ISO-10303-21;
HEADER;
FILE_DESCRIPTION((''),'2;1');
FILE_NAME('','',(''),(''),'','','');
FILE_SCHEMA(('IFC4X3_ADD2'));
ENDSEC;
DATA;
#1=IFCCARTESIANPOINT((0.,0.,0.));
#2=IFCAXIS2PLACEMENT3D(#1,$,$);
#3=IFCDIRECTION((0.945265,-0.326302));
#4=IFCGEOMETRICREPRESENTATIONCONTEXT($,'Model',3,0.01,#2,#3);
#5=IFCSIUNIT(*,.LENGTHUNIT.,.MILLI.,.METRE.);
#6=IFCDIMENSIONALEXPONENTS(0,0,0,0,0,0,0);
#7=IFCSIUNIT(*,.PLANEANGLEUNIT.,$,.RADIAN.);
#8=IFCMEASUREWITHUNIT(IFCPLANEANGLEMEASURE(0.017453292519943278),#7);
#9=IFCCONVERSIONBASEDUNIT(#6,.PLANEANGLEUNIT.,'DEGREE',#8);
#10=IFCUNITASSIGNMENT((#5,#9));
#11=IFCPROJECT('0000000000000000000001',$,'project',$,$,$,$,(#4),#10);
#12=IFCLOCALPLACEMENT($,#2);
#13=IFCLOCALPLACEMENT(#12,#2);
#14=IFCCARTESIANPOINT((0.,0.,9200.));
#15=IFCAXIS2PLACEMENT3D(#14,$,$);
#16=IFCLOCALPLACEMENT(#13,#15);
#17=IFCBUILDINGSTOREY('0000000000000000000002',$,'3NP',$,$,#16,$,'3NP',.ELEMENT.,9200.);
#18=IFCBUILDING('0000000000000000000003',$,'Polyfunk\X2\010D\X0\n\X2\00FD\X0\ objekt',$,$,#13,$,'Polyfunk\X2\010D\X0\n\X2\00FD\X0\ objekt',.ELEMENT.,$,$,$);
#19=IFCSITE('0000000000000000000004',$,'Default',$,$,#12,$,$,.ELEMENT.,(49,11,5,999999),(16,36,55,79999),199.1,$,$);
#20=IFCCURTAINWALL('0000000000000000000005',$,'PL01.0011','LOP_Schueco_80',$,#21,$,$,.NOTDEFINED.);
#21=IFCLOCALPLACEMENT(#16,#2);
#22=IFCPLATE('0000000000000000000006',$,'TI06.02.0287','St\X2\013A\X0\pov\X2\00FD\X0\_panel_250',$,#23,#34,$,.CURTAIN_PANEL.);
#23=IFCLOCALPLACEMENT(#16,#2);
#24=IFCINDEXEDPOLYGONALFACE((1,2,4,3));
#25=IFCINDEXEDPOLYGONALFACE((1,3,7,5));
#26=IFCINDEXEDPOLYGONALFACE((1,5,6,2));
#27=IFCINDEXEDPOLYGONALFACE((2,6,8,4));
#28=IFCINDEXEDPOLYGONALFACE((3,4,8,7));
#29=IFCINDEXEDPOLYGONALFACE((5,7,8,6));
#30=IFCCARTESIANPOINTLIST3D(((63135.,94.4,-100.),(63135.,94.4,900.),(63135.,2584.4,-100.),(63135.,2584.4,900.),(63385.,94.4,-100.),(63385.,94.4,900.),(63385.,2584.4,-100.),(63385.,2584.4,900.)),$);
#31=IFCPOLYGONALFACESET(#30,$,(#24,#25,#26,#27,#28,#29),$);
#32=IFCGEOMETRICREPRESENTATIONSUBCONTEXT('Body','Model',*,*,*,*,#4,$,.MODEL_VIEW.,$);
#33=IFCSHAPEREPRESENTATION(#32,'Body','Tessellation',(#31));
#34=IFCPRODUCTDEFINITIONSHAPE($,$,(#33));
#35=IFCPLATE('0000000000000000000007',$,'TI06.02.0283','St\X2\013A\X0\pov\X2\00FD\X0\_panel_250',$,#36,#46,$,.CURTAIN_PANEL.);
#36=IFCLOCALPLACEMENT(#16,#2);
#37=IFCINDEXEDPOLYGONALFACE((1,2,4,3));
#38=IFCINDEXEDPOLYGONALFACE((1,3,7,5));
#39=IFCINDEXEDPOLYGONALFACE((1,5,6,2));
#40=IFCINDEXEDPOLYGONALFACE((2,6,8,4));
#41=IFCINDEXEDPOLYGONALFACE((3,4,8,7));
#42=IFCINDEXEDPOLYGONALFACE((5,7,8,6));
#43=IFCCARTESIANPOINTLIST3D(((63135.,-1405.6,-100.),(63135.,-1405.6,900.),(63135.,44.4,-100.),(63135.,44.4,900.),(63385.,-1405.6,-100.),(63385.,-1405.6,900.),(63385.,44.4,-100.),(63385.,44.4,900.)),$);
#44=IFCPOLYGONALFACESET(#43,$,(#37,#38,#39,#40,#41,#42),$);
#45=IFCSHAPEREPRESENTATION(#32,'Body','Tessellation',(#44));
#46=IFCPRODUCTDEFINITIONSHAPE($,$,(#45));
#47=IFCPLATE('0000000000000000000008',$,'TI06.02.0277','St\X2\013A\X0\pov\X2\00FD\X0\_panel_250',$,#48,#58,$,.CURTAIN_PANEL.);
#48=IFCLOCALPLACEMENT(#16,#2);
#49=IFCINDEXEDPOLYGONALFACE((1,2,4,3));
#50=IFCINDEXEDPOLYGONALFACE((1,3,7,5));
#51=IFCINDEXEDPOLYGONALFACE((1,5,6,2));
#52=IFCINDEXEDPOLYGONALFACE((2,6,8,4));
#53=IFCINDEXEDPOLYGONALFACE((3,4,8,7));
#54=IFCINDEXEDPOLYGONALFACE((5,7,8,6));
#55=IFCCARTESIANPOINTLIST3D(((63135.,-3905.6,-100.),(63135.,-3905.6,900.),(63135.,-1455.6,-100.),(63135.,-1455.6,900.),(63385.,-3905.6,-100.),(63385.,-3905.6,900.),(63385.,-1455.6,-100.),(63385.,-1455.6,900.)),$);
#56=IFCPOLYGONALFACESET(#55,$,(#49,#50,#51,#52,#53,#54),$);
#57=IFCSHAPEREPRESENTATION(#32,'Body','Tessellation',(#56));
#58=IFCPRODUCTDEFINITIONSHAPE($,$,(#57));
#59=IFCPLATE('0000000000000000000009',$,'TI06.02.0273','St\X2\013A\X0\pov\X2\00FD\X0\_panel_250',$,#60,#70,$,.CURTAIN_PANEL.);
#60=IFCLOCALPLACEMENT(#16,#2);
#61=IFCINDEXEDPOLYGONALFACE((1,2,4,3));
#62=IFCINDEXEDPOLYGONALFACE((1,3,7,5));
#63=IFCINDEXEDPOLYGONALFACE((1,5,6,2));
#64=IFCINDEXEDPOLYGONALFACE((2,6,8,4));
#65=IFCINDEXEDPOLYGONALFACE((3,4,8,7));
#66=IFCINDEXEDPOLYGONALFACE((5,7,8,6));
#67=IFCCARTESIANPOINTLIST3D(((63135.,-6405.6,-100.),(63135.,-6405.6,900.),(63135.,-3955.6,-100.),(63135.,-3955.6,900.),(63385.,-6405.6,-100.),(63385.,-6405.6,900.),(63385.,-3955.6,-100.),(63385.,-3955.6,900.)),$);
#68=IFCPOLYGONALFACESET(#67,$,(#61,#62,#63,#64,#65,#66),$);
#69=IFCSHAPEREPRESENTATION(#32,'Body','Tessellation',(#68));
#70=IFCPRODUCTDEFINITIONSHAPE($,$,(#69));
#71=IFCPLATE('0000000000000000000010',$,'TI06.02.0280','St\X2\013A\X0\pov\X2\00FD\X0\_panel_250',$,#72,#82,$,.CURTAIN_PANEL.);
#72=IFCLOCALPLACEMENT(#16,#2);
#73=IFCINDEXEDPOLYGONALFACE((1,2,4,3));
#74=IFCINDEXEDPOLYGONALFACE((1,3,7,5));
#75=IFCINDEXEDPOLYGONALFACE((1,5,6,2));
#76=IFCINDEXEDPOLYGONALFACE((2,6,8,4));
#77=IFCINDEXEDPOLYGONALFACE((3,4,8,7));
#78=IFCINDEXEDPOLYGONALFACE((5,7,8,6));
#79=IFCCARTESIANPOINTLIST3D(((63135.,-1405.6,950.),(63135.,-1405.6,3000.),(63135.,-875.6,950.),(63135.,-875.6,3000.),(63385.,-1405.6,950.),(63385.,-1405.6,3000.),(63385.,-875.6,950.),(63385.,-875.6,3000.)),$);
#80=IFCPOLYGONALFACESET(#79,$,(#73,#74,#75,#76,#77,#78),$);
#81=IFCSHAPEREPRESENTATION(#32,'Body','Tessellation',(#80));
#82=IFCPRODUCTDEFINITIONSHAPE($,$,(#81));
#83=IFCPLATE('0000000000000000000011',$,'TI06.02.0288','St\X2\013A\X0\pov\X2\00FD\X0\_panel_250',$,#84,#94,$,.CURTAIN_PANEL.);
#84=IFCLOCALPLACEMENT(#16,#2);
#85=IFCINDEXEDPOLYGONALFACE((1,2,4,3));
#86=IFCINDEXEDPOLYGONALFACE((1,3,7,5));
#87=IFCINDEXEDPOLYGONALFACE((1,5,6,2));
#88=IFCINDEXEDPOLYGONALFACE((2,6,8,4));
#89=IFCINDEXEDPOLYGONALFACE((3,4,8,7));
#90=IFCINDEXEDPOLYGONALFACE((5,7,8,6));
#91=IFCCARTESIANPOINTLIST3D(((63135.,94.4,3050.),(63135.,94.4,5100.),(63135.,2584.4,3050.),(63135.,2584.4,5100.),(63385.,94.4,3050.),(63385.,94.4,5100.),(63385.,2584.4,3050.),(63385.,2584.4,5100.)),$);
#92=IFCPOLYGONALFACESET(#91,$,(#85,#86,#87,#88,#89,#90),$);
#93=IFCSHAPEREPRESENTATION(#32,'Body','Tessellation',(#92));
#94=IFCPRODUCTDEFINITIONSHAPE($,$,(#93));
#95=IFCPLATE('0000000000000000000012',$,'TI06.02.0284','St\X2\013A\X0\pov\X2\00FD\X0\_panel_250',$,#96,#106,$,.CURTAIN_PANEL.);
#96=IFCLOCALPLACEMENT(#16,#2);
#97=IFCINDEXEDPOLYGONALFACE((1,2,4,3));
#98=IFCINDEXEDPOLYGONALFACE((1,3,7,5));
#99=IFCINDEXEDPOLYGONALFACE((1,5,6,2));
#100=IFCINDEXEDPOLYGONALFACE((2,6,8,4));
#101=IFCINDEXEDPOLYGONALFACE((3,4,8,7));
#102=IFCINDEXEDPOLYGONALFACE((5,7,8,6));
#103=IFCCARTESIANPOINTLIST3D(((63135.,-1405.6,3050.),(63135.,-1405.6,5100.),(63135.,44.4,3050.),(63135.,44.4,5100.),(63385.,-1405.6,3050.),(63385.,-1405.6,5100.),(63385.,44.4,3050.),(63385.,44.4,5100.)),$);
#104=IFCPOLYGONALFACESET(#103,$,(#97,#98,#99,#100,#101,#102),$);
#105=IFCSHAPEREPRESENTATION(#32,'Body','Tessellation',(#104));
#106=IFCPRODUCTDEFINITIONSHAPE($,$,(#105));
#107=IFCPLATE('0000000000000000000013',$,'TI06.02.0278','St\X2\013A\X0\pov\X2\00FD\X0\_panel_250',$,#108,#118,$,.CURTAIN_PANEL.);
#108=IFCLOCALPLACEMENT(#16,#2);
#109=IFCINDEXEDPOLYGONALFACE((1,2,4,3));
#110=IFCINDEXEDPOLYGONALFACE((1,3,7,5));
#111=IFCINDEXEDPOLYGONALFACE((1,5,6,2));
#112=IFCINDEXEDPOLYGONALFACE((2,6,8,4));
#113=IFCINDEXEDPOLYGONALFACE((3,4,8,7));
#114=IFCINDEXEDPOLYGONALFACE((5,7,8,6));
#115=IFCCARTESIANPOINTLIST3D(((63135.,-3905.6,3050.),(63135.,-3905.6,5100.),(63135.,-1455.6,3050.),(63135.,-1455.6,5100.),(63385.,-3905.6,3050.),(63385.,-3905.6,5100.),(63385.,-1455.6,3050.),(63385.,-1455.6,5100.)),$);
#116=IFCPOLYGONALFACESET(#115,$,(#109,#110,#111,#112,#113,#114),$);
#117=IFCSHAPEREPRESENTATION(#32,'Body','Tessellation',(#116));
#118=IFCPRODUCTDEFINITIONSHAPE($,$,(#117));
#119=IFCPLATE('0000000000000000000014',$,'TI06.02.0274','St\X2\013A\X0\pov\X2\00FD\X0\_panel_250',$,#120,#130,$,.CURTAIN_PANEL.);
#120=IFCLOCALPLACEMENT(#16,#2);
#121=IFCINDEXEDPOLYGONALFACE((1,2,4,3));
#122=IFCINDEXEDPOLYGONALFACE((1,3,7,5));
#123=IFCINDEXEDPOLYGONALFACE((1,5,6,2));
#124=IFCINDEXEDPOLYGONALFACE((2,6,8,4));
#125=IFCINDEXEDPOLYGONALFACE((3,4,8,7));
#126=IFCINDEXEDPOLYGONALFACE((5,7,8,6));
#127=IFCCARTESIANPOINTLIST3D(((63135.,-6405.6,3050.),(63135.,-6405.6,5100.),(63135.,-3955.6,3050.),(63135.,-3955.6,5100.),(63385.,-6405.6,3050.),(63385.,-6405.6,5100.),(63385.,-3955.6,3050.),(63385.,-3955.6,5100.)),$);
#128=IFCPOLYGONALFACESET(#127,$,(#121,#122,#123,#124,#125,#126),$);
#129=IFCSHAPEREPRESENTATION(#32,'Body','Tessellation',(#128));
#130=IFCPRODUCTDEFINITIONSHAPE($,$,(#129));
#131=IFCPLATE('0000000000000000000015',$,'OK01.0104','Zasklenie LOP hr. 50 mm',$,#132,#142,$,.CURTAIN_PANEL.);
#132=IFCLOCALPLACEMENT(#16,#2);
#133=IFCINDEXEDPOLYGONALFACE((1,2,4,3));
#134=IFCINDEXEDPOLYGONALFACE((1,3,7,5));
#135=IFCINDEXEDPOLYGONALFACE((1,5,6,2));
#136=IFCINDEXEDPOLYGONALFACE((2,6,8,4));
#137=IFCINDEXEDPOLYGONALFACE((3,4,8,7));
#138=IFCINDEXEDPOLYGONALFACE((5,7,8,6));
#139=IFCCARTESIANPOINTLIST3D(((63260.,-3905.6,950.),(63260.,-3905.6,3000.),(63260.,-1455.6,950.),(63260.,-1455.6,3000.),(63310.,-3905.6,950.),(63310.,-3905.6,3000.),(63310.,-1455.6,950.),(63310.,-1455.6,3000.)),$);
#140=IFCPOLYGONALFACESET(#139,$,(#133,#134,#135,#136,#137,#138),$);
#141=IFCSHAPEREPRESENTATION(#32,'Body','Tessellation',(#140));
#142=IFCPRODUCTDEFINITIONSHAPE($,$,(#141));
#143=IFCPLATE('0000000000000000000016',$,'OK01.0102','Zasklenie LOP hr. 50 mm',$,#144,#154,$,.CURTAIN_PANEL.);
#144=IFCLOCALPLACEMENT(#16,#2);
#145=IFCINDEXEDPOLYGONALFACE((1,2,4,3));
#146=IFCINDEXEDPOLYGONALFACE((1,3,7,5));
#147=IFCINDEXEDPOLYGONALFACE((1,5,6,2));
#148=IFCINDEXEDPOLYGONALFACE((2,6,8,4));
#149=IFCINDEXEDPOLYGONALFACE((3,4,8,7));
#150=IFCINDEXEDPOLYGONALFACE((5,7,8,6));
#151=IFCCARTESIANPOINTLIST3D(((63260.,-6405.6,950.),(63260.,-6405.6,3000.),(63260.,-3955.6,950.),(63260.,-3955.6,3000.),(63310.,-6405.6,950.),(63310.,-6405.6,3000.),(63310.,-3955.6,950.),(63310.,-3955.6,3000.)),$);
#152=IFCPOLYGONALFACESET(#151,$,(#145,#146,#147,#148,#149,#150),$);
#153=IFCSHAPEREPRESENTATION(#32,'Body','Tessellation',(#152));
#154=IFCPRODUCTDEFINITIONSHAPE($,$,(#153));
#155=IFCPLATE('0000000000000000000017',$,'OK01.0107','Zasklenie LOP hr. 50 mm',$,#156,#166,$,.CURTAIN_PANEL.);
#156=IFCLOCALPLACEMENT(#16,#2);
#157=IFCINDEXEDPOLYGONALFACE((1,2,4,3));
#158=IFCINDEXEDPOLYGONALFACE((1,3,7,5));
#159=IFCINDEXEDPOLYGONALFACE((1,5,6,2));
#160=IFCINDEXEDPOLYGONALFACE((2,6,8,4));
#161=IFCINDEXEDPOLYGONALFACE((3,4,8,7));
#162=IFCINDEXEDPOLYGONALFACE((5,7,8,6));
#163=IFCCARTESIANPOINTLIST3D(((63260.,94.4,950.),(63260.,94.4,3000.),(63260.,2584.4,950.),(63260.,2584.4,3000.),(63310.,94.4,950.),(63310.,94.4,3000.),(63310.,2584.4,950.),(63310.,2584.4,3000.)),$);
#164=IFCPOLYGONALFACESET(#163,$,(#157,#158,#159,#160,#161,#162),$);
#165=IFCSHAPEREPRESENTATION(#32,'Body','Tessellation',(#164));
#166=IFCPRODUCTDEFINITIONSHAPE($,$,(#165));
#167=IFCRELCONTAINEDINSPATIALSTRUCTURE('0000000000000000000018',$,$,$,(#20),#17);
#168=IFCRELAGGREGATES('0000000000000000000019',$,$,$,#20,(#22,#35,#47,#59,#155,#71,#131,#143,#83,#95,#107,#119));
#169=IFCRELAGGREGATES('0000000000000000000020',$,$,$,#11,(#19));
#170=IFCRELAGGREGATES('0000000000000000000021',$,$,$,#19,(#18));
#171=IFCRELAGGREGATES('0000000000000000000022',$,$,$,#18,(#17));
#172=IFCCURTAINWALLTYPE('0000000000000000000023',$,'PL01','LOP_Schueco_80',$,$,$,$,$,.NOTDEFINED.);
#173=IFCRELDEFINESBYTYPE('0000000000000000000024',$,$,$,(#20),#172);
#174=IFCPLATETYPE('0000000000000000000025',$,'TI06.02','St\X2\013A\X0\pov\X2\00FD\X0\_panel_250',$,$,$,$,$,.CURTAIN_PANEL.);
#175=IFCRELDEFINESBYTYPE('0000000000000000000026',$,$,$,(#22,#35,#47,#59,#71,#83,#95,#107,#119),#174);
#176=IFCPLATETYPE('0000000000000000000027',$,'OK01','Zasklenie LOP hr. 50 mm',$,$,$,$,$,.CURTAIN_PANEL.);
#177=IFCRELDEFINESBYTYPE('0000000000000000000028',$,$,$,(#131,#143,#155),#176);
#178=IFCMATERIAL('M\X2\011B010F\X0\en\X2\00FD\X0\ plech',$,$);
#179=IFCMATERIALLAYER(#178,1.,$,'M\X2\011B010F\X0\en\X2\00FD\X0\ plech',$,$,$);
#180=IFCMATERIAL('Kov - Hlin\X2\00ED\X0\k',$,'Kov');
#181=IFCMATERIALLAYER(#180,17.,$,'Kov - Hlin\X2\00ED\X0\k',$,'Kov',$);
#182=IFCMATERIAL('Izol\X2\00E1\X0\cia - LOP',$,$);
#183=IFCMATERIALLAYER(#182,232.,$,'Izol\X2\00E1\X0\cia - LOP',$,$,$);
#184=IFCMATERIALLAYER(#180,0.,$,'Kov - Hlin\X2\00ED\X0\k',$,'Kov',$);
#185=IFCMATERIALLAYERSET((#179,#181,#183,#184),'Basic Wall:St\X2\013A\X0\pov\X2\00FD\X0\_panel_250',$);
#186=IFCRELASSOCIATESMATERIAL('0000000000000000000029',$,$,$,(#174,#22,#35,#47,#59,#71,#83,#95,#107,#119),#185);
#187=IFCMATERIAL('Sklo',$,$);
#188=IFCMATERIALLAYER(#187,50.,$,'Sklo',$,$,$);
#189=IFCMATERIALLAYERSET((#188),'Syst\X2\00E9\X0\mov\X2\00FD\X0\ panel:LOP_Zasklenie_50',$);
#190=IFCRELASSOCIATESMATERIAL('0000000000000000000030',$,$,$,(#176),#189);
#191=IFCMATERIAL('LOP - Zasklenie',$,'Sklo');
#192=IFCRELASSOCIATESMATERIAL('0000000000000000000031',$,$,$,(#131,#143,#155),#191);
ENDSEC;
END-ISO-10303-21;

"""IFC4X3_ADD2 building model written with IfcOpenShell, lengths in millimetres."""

from ifc_helpers import new_model, entity, si_unit, converted_unit, direction, frame, frame_2d, origin, origin_2d_with_axis, place, context, subcontext, project, spatial, rectangle, extrude, source, transform, mapped, material, layer, layer_set, layer_usage, type_object, type_shapes, element, aggregate, save


model = new_model("IFC4X3_ADD2")

# Units and contexts
model_context = context("Model", 3, precision=0.01, world=origin(), true_north=direction((0.945265, -0.326302)))
body_context = subcontext(model_context, "Body", "Model", "MODEL_VIEW")
ifc_project = project(units=[si_unit("LENGTHUNIT", "METRE", prefix="MILLI"), converted_unit("PLANEANGLEUNIT", "DEGREE", entity("IfcPlaneAngleMeasure", 0.017453292519943278), si_unit("PLANEANGLEUNIT", "RADIAN"), dimensions=[0, 0, 0, 0, 0, 0, 0])], contexts=[model_context])

# Site, building, storey
site_placement = place(None, origin())
site = spatial("IfcSite", under=ifc_project, at=site_placement, Name="Default", CompositionType="ELEMENT", RefLatitude=(49, 11, 5, 999999), RefLongitude=(16, 36, 55, 79999), RefElevation=199.1)
building_placement = place(site_placement, origin())
building = spatial("IfcBuilding", under=site, at=building_placement, Name="Polyfunkčný objekt", LongName="Polyfunkčný objekt", CompositionType="ELEMENT")
storey_placement = place(building_placement, frame((0.0, 0.0, 9200.0)))
storey = spatial("IfcBuildingStorey", under=building, at=storey_placement, Name="3NP", LongName="3NP", CompositionType="ELEMENT", Elevation=9200.0)

# Curtain wall, plates
curtain_wall_type = type_object("IfcCurtainWallType", Name="PL01", Description="LOP_Schueco_80", PredefinedType="NOTDEFINED")
curtain_wall_placement = place(storey_placement, frame((0.0, 0.0, -9200.0)))
curtain_wall = element("IfcCurtainWall", 1, at=curtain_wall_placement, inside=storey, type_object=curtain_wall_type, Name="PL01.0011", Description="LOP_Schueco_80", PredefinedType="NOTDEFINED")
ifc_material_1 = material(Name="Měďený plech")
ifc_layer_1 = layer(ifc_material_1, 1.0, Name="Měďený plech")
ifc_material_2 = material(Name="Kov - Hliník", Category="Kov")
ifc_layer_2 = layer(ifc_material_2, 17.0, Name="Kov - Hliník", Category="Kov")
ifc_material_3 = material(Name="Izolácia - LOP")
ifc_layer_3 = layer(ifc_material_3, 232.0, Name="Izolácia - LOP")
ifc_layer_4 = layer(ifc_material_2, 0.0, Name="Kov - Hliník", Category="Kov")
ifc_layer_set_1 = layer_set([ifc_layer_1, ifc_layer_2, ifc_layer_3, ifc_layer_4], Name="Basic Wall:Stĺpový_panel_250")
ifc_layer_usage_1 = layer_usage(ifc_layer_set_1, "AXIS2", "NEGATIVE", 125.0)
plate_type_1 = type_object("IfcPlateType", Name="TI06.02", Description="Stĺpový_panel_250", PredefinedType="CURTAIN_PANEL", material=ifc_layer_set_1)
plate_1_placement = place(storey_placement, frame((63260.0, 2584.4, -100.0), z_axis=(0.0, 0.0, 1.0), x_axis=(0.0, -1.0, 0.0)))
plate_1 = element("IfcPlate", 2, at=plate_1_placement, type_object=plate_type_1, material=ifc_layer_usage_1, Name="TI06.02.0287", Description="Stĺpový_panel_250", PredefinedType="CURTAIN_PANEL", context=body_context, shape_type="SweptSolid", body=[
    extrude(rectangle(XDim=250.0, YDim=2490.0, at=frame_2d((0.0, 0.0), x_axis=(1.0, 0.0))), frame((1245.0, 0.0, 0.0), z_axis=(0.0, 0.0, 1.0), x_axis=(0.0, 1.0, 0.0)), (0.0, 0.0, 1.0), 1000.0),
])
ifc_layer_usage_2 = layer_usage(ifc_layer_set_1, "AXIS2", "NEGATIVE", 125.0)
plate_2_placement = place(storey_placement, frame((63260.0, 44.4, -100.0), z_axis=(0.0, 0.0, 1.0), x_axis=(0.0, -1.0, 0.0)))
plate_2 = element("IfcPlate", 3, at=plate_2_placement, type_object=plate_type_1, material=ifc_layer_usage_2, Name="TI06.02.0283", Description="Stĺpový_panel_250", PredefinedType="CURTAIN_PANEL", context=body_context, shape_type="SweptSolid", body=[
    extrude(rectangle(XDim=250.0, YDim=1450.0, at=frame_2d((0.0, 0.0), x_axis=(1.0, 0.0))), frame((725.0, 0.0, 0.0), z_axis=(0.0, 0.0, 1.0), x_axis=(0.0, 1.0, 0.0)), (0.0, 0.0, 1.0), 1000.0),
])
ifc_layer_usage_3 = layer_usage(ifc_layer_set_1, "AXIS2", "NEGATIVE", 125.0)
plate_3_placement = place(storey_placement, frame((63260.0, -1455.6, -100.0), z_axis=(0.0, 0.0, 1.0), x_axis=(0.0, -1.0, 0.0)))
plate_3 = element("IfcPlate", 4, at=plate_3_placement, type_object=plate_type_1, material=ifc_layer_usage_3, Name="TI06.02.0277", Description="Stĺpový_panel_250", PredefinedType="CURTAIN_PANEL", context=body_context, shape_type="SweptSolid", body=[
    extrude(rectangle(XDim=250.0, YDim=2450.0, at=frame_2d((0.0, 0.0), x_axis=(1.0, 0.0))), frame((1225.0, 0.0, 0.0), z_axis=(0.0, 0.0, 1.0), x_axis=(0.0, 1.0, 0.0)), (0.0, 0.0, 1.0), 1000.0),
])
ifc_layer_usage_4 = layer_usage(ifc_layer_set_1, "AXIS2", "NEGATIVE", 125.0)
plate_4_placement = place(storey_placement, frame((63260.0, -3955.6, -100.0), z_axis=(0.0, 0.0, 1.0), x_axis=(0.0, -1.0, 0.0)))
plate_4 = element("IfcPlate", 5, at=plate_4_placement, type_object=plate_type_1, material=ifc_layer_usage_4, Name="TI06.02.0273", Description="Stĺpový_panel_250", PredefinedType="CURTAIN_PANEL", context=body_context, shape_type="SweptSolid", body=[
    extrude(rectangle(XDim=250.0, YDim=2450.0, at=frame_2d((0.0, 0.0), x_axis=(1.0, 0.0))), frame((1225.0, 0.0, 0.0), z_axis=(0.0, 0.0, 1.0), x_axis=(0.0, 1.0, 0.0)), (0.0, 0.0, 1.0), 1000.0),
])
ifc_layer_usage_5 = layer_usage(ifc_layer_set_1, "AXIS2", "NEGATIVE", 125.0)
plate_5_placement = place(storey_placement, frame((63260.0, -875.6, 950.0), z_axis=(0.0, 0.0, 1.0), x_axis=(0.0, -1.0, 0.0)))
plate_5 = element("IfcPlate", 6, at=plate_5_placement, type_object=plate_type_1, material=ifc_layer_usage_5, Name="TI06.02.0280", Description="Stĺpový_panel_250", PredefinedType="CURTAIN_PANEL", context=body_context, shape_type="SweptSolid", body=[
    extrude(rectangle(XDim=250.0, YDim=530.0, at=frame_2d((0.0, 0.0), x_axis=(1.0, 0.0))), frame((265.0, 0.0, 0.0), z_axis=(0.0, 0.0, 1.0), x_axis=(0.0, 1.0, 0.0)), (0.0, 0.0, 1.0), 2050.0),
])
ifc_layer_usage_6 = layer_usage(ifc_layer_set_1, "AXIS2", "NEGATIVE", 125.0)
plate_6_placement = place(storey_placement, frame((63260.0, 2584.4, 3050.0), z_axis=(0.0, 0.0, 1.0), x_axis=(0.0, -1.0, 0.0)))
plate_6 = element("IfcPlate", 7, at=plate_6_placement, type_object=plate_type_1, material=ifc_layer_usage_6, Name="TI06.02.0288", Description="Stĺpový_panel_250", PredefinedType="CURTAIN_PANEL", context=body_context, shape_type="SweptSolid", body=[
    extrude(rectangle(XDim=250.0, YDim=2490.0, at=frame_2d((0.0, 0.0), x_axis=(1.0, 0.0))), frame((1245.0, 0.0, 0.0), z_axis=(0.0, 0.0, 1.0), x_axis=(0.0, 1.0, 0.0)), (0.0, 0.0, 1.0), 2050.0),
])
ifc_layer_usage_7 = layer_usage(ifc_layer_set_1, "AXIS2", "NEGATIVE", 125.0)
plate_7_placement = place(storey_placement, frame((63260.0, 44.4, 3050.0), z_axis=(0.0, 0.0, 1.0), x_axis=(0.0, -1.0, 0.0)))
plate_7 = element("IfcPlate", 8, at=plate_7_placement, type_object=plate_type_1, material=ifc_layer_usage_7, Name="TI06.02.0284", Description="Stĺpový_panel_250", PredefinedType="CURTAIN_PANEL", context=body_context, shape_type="SweptSolid", body=[
    extrude(rectangle(XDim=250.0, YDim=1450.0, at=frame_2d((0.0, 0.0), x_axis=(1.0, 0.0))), frame((725.0, 0.0, 0.0), z_axis=(0.0, 0.0, 1.0), x_axis=(0.0, 1.0, 0.0)), (0.0, 0.0, 1.0), 2050.0),
])
ifc_layer_usage_8 = layer_usage(ifc_layer_set_1, "AXIS2", "NEGATIVE", 125.0)
plate_8_placement = place(storey_placement, frame((63260.0, -1455.6, 3050.0), z_axis=(0.0, 0.0, 1.0), x_axis=(0.0, -1.0, 0.0)))
plate_8 = element("IfcPlate", 9, at=plate_8_placement, type_object=plate_type_1, material=ifc_layer_usage_8, Name="TI06.02.0278", Description="Stĺpový_panel_250", PredefinedType="CURTAIN_PANEL", context=body_context, shape_type="SweptSolid", body=[
    extrude(rectangle(XDim=250.0, YDim=2450.0, at=frame_2d((0.0, 0.0), x_axis=(1.0, 0.0))), frame((1225.0, 0.0, 0.0), z_axis=(0.0, 0.0, 1.0), x_axis=(0.0, 1.0, 0.0)), (0.0, 0.0, 1.0), 2050.0),
])
ifc_layer_usage_9 = layer_usage(ifc_layer_set_1, "AXIS2", "NEGATIVE", 125.0)
plate_9_placement = place(storey_placement, frame((63260.0, -3955.6, 3050.0), z_axis=(0.0, 0.0, 1.0), x_axis=(0.0, -1.0, 0.0)))
plate_9 = element("IfcPlate", 10, at=plate_9_placement, type_object=plate_type_1, material=ifc_layer_usage_9, Name="TI06.02.0274", Description="Stĺpový_panel_250", PredefinedType="CURTAIN_PANEL", context=body_context, shape_type="SweptSolid", body=[
    extrude(rectangle(XDim=250.0, YDim=2450.0, at=frame_2d((0.0, 0.0), x_axis=(1.0, 0.0))), frame((1225.0, 0.0, 0.0), z_axis=(0.0, 0.0, 1.0), x_axis=(0.0, 1.0, 0.0)), (0.0, 0.0, 1.0), 2050.0),
])
ifc_material_4 = material(Name="LOP - Zasklenie", Category="Sklo")
ifc_material_5 = material(Name="Sklo")
ifc_layer_5 = layer(ifc_material_5, 50.0, Name="Sklo")
ifc_layer_set_2 = layer_set([ifc_layer_5], Name="Systémový panel:LOP_Zasklenie_50")
plate_type_2 = type_object("IfcPlateType", Name="OK01", Description="Zasklenie LOP hr. 50 mm", PredefinedType="CURTAIN_PANEL", material=ifc_layer_set_2)
shared_shape_1 = source(origin(), body_context, "Body", "SweptSolid", [
    extrude(rectangle(XDim=50.0, YDim=2450.0, at=origin_2d_with_axis()), frame((0.0, 25.0, 0.0), z_axis=(0.0, 0.0, 1.0), x_axis=(0.0, 1.0, 0.0)), (0.0, 0.0, 1.0), 2050.0),
])
plate_10_placement = place(curtain_wall_placement, frame((63260.0, -2680.6, 10150.0), z_axis=(0.0, 0.0, 1.0), x_axis=(0.0, -1.0, 0.0)))
plate_10 = element("IfcPlate", 11, at=plate_10_placement, type_object=plate_type_2, material=ifc_material_4, Name="OK01.0104", Description="Zasklenie LOP hr. 50 mm", PredefinedType="CURTAIN_PANEL", context=body_context, shape_type="MappedRepresentation", body=[
    mapped(shared_shape_1, transform((0.0, 0.0, 0.0), scale=1.0)),
])
plate_11_placement = place(curtain_wall_placement, frame((63260.0, -5180.6, 10150.0), z_axis=(0.0, 0.0, 1.0), x_axis=(0.0, -1.0, 0.0)))
plate_11 = element("IfcPlate", 12, at=plate_11_placement, type_object=plate_type_2, material=ifc_material_4, Name="OK01.0102", Description="Zasklenie LOP hr. 50 mm", PredefinedType="CURTAIN_PANEL", context=body_context, shape_type="MappedRepresentation", body=[
    mapped(shared_shape_1, transform((0.0, 0.0, 0.0), scale=1.0)),
])
shared_shape_2 = source(origin(), body_context, "Body", "SweptSolid", [
    extrude(rectangle(XDim=50.0, YDim=2490.0, at=origin_2d_with_axis()), frame((0.0, 25.0, 0.0), z_axis=(0.0, 0.0, 1.0), x_axis=(0.0, 1.0, 0.0)), (0.0, 0.0, 1.0), 2050.0),
])
type_shapes(plate_type_2, [shared_shape_1, shared_shape_2])
plate_12_placement = place(curtain_wall_placement, frame((63260.0, 1339.4, 10150.0), z_axis=(0.0, 0.0, 1.0), x_axis=(0.0, -1.0, 0.0)))
plate_12 = element("IfcPlate", 13, at=plate_12_placement, type_object=plate_type_2, material=ifc_material_4, Name="OK01.0107", Description="Zasklenie LOP hr. 50 mm", PredefinedType="CURTAIN_PANEL", context=body_context, shape_type="MappedRepresentation", body=[
    mapped(shared_shape_2, transform((0.0, 0.0, 0.0), scale=1.0)),
])
aggregate(curtain_wall, [plate_1, plate_2, plate_3, plate_4, plate_12, plate_5, plate_10, plate_11, plate_6, plate_7, plate_8, plate_9])

save(model, "model.ifc")
